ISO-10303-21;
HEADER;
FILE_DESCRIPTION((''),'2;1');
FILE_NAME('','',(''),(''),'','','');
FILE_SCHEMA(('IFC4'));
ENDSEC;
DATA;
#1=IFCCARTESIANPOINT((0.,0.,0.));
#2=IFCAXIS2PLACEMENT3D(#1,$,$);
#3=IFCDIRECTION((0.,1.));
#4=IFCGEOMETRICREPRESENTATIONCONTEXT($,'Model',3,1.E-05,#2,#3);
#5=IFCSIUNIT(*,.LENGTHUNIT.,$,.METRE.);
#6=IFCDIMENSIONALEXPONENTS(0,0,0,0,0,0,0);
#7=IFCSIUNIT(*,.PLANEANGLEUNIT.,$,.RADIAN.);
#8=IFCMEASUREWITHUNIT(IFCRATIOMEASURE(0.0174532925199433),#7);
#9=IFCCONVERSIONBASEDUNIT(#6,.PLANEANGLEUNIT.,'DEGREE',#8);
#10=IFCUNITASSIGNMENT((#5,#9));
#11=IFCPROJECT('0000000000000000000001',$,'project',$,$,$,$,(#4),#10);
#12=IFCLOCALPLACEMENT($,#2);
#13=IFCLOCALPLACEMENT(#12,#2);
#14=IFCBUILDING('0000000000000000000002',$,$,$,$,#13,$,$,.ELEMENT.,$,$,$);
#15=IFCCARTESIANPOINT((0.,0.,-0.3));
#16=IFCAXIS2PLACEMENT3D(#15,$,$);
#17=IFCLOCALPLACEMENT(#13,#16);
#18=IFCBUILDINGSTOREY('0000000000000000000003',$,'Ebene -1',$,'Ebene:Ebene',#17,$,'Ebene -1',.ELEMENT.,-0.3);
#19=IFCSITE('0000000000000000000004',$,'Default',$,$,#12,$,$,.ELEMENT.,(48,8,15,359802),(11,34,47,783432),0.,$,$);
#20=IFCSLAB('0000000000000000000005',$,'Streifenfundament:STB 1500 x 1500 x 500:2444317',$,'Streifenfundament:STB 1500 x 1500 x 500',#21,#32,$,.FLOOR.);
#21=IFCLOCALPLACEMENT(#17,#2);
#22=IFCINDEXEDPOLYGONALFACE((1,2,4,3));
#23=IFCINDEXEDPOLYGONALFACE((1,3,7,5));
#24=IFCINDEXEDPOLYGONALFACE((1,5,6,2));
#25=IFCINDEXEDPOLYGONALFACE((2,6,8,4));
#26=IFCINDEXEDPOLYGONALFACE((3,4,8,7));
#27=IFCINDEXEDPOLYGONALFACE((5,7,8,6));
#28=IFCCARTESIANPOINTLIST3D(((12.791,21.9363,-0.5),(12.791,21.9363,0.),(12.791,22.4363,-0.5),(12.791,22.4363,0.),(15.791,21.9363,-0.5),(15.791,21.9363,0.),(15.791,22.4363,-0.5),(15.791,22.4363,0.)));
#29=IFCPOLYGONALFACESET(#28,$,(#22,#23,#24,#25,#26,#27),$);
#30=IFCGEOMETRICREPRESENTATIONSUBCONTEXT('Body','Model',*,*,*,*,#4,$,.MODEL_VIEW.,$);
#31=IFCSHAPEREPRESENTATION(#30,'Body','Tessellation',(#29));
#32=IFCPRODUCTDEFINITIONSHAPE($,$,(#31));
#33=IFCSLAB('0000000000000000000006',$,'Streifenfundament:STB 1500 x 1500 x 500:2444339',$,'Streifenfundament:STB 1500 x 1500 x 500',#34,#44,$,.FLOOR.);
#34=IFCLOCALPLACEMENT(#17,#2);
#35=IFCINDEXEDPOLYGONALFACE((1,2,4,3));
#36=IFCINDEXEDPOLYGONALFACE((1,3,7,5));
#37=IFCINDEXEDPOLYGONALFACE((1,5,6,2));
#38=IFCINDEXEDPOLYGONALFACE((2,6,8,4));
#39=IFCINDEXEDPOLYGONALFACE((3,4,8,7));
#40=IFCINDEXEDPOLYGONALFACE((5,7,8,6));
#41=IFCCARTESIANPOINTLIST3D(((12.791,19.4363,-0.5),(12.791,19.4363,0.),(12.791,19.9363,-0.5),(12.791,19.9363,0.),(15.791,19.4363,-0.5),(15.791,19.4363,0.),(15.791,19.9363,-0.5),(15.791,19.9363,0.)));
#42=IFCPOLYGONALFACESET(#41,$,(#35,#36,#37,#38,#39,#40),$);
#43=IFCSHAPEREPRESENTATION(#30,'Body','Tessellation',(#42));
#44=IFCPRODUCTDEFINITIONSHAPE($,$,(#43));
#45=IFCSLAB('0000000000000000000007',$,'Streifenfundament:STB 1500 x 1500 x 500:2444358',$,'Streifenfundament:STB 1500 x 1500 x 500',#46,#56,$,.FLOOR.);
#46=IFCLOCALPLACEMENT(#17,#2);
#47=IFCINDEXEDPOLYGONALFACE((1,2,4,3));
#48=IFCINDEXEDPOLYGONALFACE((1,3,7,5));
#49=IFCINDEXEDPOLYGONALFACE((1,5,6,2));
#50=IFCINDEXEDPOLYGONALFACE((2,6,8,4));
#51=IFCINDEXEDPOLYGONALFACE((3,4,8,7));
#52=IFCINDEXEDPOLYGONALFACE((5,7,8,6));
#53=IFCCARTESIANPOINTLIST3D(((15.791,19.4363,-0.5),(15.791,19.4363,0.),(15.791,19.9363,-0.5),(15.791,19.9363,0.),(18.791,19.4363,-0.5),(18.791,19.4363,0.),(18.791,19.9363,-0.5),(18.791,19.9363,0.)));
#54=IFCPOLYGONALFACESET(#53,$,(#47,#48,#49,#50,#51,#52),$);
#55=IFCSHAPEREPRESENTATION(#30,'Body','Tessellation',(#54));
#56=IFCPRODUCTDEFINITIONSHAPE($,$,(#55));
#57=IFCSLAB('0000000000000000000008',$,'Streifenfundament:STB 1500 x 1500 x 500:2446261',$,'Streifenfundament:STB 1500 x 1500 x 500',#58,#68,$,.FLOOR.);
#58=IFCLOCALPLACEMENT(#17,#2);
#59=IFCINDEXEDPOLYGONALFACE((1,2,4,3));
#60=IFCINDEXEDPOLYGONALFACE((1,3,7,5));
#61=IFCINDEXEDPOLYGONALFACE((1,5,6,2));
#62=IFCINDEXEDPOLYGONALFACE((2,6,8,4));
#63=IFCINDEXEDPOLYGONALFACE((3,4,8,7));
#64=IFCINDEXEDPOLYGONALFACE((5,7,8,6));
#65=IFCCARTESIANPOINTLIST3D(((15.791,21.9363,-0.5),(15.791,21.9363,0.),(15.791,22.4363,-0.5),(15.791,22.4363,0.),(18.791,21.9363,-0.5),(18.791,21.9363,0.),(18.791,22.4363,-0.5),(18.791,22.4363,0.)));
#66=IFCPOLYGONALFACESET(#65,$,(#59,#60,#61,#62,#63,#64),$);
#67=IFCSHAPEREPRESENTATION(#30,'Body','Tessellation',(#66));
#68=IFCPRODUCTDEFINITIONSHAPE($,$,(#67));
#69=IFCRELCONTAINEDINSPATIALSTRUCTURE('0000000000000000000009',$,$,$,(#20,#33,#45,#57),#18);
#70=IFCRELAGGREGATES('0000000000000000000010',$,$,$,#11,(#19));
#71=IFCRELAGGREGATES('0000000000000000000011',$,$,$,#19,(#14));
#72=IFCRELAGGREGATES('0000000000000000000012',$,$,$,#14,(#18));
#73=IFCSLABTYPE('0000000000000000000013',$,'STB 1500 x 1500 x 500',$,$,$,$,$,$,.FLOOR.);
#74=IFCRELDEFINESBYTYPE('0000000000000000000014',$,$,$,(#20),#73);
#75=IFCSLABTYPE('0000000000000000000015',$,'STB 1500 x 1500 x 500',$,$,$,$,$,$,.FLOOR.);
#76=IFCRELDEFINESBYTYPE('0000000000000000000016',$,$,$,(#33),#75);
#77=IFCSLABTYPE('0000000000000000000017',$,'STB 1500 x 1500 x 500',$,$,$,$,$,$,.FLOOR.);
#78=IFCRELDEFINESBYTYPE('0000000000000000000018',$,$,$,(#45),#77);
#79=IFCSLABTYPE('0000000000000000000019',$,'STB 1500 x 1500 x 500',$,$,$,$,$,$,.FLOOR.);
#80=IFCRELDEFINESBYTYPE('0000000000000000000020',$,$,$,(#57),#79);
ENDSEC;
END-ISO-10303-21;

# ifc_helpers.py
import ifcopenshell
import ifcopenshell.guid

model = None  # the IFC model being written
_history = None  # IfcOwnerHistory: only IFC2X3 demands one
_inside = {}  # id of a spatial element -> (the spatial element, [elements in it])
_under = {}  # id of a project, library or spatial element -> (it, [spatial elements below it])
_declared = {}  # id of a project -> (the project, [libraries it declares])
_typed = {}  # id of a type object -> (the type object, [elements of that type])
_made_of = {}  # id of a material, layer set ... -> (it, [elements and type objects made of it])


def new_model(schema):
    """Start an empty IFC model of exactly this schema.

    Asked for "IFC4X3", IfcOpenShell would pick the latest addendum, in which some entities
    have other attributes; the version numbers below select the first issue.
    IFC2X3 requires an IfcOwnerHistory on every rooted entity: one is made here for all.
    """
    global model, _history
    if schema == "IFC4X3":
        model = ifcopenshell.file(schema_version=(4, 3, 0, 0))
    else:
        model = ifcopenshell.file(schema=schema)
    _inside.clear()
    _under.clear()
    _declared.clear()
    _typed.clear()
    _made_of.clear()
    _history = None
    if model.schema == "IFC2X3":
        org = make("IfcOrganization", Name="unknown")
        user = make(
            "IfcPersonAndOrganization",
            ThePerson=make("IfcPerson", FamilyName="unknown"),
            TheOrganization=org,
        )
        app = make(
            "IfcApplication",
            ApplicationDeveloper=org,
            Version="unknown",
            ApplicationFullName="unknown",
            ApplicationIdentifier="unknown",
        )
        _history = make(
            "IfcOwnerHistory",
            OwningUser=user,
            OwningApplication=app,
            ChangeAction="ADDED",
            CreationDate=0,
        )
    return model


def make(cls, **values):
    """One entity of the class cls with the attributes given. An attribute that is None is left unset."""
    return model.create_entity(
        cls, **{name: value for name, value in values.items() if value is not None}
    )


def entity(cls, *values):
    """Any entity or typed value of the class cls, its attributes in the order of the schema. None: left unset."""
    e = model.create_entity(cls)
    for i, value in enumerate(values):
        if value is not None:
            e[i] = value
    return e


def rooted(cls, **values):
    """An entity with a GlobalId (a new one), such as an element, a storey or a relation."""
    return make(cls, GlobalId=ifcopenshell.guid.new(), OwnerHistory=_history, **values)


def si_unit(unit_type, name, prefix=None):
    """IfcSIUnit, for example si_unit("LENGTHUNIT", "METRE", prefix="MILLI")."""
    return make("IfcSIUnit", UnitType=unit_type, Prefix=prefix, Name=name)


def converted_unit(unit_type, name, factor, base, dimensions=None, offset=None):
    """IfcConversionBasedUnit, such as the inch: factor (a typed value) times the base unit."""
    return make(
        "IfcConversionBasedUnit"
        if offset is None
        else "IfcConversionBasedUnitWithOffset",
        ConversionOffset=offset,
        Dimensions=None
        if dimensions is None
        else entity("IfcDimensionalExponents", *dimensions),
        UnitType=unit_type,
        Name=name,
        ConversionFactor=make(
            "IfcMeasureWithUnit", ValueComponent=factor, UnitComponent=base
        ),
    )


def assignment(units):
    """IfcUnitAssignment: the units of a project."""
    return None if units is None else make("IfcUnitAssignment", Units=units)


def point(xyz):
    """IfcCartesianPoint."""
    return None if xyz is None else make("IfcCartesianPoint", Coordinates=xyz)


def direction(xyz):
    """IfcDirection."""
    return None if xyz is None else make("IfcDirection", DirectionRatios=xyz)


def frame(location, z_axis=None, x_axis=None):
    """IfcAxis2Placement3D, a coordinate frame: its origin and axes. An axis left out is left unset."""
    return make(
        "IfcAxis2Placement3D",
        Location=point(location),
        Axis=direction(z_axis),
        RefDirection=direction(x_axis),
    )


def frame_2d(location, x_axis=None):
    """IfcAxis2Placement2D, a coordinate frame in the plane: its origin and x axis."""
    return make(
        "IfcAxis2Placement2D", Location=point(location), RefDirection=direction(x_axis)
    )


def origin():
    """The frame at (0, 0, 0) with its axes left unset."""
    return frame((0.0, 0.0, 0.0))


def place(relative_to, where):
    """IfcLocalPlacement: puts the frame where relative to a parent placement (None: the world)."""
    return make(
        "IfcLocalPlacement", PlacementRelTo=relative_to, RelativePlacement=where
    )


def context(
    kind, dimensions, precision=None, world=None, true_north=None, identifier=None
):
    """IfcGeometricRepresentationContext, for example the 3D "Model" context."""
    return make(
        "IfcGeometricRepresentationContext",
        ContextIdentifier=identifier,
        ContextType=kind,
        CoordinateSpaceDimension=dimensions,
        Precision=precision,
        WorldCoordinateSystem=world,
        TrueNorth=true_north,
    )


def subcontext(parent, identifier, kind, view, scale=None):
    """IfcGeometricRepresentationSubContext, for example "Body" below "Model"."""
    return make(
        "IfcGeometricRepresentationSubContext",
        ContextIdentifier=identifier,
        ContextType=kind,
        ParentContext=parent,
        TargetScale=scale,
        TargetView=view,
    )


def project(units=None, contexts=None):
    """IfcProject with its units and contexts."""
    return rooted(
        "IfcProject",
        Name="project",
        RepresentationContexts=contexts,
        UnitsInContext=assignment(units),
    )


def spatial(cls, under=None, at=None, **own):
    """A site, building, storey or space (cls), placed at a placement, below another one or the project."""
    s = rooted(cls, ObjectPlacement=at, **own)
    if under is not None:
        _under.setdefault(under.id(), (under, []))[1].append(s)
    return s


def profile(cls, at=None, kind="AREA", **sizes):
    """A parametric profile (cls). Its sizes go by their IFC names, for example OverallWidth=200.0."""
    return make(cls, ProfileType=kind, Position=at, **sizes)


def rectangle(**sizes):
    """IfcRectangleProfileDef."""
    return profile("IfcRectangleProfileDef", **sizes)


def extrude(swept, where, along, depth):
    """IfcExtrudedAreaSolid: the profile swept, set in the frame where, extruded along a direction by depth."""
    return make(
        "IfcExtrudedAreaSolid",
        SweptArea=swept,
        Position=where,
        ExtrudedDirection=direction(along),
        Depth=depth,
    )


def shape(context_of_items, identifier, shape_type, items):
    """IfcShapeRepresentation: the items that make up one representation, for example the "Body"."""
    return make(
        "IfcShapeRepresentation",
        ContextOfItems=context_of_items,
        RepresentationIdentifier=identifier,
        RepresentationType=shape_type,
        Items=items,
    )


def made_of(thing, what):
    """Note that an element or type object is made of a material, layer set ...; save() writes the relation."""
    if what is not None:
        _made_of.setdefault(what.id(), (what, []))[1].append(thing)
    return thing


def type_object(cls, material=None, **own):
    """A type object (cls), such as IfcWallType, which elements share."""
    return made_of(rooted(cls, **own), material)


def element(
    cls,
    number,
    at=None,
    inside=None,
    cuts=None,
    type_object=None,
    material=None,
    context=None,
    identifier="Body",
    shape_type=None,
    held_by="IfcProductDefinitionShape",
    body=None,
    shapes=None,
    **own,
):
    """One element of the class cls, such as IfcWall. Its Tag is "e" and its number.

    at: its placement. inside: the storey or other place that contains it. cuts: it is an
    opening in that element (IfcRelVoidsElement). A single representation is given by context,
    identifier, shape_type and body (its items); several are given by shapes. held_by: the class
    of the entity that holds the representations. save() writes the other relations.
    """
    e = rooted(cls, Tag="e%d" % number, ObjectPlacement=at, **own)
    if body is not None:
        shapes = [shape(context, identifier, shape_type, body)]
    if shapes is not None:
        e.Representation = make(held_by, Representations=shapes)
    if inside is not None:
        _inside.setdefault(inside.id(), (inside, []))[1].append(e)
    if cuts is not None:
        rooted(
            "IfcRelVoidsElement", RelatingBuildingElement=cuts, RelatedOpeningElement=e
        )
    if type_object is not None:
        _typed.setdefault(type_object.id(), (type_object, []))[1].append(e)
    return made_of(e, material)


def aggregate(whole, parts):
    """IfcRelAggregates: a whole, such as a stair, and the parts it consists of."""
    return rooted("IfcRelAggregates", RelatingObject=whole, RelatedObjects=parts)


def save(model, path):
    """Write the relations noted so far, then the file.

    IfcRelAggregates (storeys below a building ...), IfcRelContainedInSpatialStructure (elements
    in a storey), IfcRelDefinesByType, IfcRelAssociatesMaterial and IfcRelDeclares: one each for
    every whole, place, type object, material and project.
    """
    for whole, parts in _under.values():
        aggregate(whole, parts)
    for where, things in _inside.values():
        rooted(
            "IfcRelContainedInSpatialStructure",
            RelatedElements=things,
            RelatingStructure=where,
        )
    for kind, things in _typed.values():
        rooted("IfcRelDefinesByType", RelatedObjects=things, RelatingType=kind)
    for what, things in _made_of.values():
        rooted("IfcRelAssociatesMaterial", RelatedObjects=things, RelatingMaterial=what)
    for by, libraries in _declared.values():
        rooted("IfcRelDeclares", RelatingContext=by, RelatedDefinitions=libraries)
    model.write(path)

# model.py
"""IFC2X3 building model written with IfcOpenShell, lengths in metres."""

from ifc_helpers import new_model, entity, si_unit, converted_unit, direction, frame, frame_2d, origin, place, context, subcontext, project, spatial, rectangle, extrude, type_object, element, save


model = new_model("IFC2X3")

# Units and contexts
model_context = context("Model", 3, precision=1e-05, world=origin(), true_north=direction((0.0, 1.0)))
body_context = subcontext(model_context, "Body", "Model", "MODEL_VIEW")
ifc_project = project(units=[si_unit("LENGTHUNIT", "METRE"), converted_unit("PLANEANGLEUNIT", "DEGREE", entity("IfcRatioMeasure", 0.0174532925199433), si_unit("PLANEANGLEUNIT", "RADIAN"), dimensions=[0, 0, 0, 0, 0, 0, 0])], contexts=[model_context])

# Site, building, storey
site_placement = place(None, origin())
site = spatial("IfcSite", under=ifc_project, at=site_placement, Name="Default", CompositionType="ELEMENT", RefLatitude=(48, 8, 15, 359802), RefLongitude=(11, 34, 47, 783432), RefElevation=0.0)
building_placement = place(site_placement, origin())
building = spatial("IfcBuilding", under=site, at=building_placement, CompositionType="ELEMENT")
storey_placement = place(building_placement, frame((0.0, 0.0, -0.3)))
storey = spatial("IfcBuildingStorey", under=building, at=storey_placement, Name="Ebene -1", ObjectType="Ebene:Ebene", LongName="Ebene -1", CompositionType="ELEMENT", Elevation=-0.3)

# Slabs
slab_type_1 = type_object("IfcSlabType", Name="STB 1500 x 1500 x 500", PredefinedType="FLOOR")
slab_1_placement = place(storey_placement, origin())
element("IfcSlab", 1, at=slab_1_placement, inside=storey, type_object=slab_type_1, Name="Streifenfundament:STB 1500 x 1500 x 500:2444317", ObjectType="Streifenfundament:STB 1500 x 1500 x 500", PredefinedType="FLOOR", context=body_context, shape_type="SweptSolid", body=[
    extrude(rectangle(XDim=3.0, YDim=0.5, at=frame_2d((0.0, 0.0), x_axis=(1.0, 0.0))), frame((14.291, 22.1863, -0.5), z_axis=(0.0, 0.0, 1.0), x_axis=(-1.0, 0.0, 0.0)), (0.0, 0.0, 1.0), 0.5),
])
slab_type_2 = type_object("IfcSlabType", Name="STB 1500 x 1500 x 500", PredefinedType="FLOOR")
slab_2_placement = place(storey_placement, origin())
element("IfcSlab", 2, at=slab_2_placement, inside=storey, type_object=slab_type_2, Name="Streifenfundament:STB 1500 x 1500 x 500:2444339", ObjectType="Streifenfundament:STB 1500 x 1500 x 500", PredefinedType="FLOOR", context=body_context, shape_type="SweptSolid", body=[
    extrude(rectangle(XDim=3.0, YDim=0.5, at=frame_2d((0.0, 0.0), x_axis=(1.0, 0.0))), frame((14.291, 19.6863, -0.5), z_axis=(0.0, 0.0, 1.0), x_axis=(-1.0, 0.0, 0.0)), (0.0, 0.0, 1.0), 0.5),
])
slab_type_3 = type_object("IfcSlabType", Name="STB 1500 x 1500 x 500", PredefinedType="FLOOR")
slab_3_placement = place(storey_placement, origin())
element("IfcSlab", 3, at=slab_3_placement, inside=storey, type_object=slab_type_3, Name="Streifenfundament:STB 1500 x 1500 x 500:2444358", ObjectType="Streifenfundament:STB 1500 x 1500 x 500", PredefinedType="FLOOR", context=body_context, shape_type="SweptSolid", body=[
    extrude(rectangle(XDim=3.0, YDim=0.5, at=frame_2d((0.0, 0.0), x_axis=(1.0, 0.0))), frame((17.291, 19.6863, -0.5), z_axis=(0.0, 0.0, 1.0), x_axis=(-1.0, 0.0, 0.0)), (0.0, 0.0, 1.0), 0.5),
])
slab_type_4 = type_object("IfcSlabType", Name="STB 1500 x 1500 x 500", PredefinedType="FLOOR")
slab_4_placement = place(storey_placement, origin())
element("IfcSlab", 4, at=slab_4_placement, inside=storey, type_object=slab_type_4, Name="Streifenfundament:STB 1500 x 1500 x 500:2446261", ObjectType="Streifenfundament:STB 1500 x 1500 x 500", PredefinedType="FLOOR", context=body_context, shape_type="SweptSolid", body=[
    extrude(rectangle(XDim=3.0, YDim=0.5, at=frame_2d((0.0, 0.0), x_axis=(1.0, 0.0))), frame((17.291, 22.1863, -0.5), z_axis=(0.0, 0.0, 1.0), x_axis=(-1.0, 0.0, 0.0)), (0.0, 0.0, 1.0), 0.5),
])

save(model, "model.ifc")
